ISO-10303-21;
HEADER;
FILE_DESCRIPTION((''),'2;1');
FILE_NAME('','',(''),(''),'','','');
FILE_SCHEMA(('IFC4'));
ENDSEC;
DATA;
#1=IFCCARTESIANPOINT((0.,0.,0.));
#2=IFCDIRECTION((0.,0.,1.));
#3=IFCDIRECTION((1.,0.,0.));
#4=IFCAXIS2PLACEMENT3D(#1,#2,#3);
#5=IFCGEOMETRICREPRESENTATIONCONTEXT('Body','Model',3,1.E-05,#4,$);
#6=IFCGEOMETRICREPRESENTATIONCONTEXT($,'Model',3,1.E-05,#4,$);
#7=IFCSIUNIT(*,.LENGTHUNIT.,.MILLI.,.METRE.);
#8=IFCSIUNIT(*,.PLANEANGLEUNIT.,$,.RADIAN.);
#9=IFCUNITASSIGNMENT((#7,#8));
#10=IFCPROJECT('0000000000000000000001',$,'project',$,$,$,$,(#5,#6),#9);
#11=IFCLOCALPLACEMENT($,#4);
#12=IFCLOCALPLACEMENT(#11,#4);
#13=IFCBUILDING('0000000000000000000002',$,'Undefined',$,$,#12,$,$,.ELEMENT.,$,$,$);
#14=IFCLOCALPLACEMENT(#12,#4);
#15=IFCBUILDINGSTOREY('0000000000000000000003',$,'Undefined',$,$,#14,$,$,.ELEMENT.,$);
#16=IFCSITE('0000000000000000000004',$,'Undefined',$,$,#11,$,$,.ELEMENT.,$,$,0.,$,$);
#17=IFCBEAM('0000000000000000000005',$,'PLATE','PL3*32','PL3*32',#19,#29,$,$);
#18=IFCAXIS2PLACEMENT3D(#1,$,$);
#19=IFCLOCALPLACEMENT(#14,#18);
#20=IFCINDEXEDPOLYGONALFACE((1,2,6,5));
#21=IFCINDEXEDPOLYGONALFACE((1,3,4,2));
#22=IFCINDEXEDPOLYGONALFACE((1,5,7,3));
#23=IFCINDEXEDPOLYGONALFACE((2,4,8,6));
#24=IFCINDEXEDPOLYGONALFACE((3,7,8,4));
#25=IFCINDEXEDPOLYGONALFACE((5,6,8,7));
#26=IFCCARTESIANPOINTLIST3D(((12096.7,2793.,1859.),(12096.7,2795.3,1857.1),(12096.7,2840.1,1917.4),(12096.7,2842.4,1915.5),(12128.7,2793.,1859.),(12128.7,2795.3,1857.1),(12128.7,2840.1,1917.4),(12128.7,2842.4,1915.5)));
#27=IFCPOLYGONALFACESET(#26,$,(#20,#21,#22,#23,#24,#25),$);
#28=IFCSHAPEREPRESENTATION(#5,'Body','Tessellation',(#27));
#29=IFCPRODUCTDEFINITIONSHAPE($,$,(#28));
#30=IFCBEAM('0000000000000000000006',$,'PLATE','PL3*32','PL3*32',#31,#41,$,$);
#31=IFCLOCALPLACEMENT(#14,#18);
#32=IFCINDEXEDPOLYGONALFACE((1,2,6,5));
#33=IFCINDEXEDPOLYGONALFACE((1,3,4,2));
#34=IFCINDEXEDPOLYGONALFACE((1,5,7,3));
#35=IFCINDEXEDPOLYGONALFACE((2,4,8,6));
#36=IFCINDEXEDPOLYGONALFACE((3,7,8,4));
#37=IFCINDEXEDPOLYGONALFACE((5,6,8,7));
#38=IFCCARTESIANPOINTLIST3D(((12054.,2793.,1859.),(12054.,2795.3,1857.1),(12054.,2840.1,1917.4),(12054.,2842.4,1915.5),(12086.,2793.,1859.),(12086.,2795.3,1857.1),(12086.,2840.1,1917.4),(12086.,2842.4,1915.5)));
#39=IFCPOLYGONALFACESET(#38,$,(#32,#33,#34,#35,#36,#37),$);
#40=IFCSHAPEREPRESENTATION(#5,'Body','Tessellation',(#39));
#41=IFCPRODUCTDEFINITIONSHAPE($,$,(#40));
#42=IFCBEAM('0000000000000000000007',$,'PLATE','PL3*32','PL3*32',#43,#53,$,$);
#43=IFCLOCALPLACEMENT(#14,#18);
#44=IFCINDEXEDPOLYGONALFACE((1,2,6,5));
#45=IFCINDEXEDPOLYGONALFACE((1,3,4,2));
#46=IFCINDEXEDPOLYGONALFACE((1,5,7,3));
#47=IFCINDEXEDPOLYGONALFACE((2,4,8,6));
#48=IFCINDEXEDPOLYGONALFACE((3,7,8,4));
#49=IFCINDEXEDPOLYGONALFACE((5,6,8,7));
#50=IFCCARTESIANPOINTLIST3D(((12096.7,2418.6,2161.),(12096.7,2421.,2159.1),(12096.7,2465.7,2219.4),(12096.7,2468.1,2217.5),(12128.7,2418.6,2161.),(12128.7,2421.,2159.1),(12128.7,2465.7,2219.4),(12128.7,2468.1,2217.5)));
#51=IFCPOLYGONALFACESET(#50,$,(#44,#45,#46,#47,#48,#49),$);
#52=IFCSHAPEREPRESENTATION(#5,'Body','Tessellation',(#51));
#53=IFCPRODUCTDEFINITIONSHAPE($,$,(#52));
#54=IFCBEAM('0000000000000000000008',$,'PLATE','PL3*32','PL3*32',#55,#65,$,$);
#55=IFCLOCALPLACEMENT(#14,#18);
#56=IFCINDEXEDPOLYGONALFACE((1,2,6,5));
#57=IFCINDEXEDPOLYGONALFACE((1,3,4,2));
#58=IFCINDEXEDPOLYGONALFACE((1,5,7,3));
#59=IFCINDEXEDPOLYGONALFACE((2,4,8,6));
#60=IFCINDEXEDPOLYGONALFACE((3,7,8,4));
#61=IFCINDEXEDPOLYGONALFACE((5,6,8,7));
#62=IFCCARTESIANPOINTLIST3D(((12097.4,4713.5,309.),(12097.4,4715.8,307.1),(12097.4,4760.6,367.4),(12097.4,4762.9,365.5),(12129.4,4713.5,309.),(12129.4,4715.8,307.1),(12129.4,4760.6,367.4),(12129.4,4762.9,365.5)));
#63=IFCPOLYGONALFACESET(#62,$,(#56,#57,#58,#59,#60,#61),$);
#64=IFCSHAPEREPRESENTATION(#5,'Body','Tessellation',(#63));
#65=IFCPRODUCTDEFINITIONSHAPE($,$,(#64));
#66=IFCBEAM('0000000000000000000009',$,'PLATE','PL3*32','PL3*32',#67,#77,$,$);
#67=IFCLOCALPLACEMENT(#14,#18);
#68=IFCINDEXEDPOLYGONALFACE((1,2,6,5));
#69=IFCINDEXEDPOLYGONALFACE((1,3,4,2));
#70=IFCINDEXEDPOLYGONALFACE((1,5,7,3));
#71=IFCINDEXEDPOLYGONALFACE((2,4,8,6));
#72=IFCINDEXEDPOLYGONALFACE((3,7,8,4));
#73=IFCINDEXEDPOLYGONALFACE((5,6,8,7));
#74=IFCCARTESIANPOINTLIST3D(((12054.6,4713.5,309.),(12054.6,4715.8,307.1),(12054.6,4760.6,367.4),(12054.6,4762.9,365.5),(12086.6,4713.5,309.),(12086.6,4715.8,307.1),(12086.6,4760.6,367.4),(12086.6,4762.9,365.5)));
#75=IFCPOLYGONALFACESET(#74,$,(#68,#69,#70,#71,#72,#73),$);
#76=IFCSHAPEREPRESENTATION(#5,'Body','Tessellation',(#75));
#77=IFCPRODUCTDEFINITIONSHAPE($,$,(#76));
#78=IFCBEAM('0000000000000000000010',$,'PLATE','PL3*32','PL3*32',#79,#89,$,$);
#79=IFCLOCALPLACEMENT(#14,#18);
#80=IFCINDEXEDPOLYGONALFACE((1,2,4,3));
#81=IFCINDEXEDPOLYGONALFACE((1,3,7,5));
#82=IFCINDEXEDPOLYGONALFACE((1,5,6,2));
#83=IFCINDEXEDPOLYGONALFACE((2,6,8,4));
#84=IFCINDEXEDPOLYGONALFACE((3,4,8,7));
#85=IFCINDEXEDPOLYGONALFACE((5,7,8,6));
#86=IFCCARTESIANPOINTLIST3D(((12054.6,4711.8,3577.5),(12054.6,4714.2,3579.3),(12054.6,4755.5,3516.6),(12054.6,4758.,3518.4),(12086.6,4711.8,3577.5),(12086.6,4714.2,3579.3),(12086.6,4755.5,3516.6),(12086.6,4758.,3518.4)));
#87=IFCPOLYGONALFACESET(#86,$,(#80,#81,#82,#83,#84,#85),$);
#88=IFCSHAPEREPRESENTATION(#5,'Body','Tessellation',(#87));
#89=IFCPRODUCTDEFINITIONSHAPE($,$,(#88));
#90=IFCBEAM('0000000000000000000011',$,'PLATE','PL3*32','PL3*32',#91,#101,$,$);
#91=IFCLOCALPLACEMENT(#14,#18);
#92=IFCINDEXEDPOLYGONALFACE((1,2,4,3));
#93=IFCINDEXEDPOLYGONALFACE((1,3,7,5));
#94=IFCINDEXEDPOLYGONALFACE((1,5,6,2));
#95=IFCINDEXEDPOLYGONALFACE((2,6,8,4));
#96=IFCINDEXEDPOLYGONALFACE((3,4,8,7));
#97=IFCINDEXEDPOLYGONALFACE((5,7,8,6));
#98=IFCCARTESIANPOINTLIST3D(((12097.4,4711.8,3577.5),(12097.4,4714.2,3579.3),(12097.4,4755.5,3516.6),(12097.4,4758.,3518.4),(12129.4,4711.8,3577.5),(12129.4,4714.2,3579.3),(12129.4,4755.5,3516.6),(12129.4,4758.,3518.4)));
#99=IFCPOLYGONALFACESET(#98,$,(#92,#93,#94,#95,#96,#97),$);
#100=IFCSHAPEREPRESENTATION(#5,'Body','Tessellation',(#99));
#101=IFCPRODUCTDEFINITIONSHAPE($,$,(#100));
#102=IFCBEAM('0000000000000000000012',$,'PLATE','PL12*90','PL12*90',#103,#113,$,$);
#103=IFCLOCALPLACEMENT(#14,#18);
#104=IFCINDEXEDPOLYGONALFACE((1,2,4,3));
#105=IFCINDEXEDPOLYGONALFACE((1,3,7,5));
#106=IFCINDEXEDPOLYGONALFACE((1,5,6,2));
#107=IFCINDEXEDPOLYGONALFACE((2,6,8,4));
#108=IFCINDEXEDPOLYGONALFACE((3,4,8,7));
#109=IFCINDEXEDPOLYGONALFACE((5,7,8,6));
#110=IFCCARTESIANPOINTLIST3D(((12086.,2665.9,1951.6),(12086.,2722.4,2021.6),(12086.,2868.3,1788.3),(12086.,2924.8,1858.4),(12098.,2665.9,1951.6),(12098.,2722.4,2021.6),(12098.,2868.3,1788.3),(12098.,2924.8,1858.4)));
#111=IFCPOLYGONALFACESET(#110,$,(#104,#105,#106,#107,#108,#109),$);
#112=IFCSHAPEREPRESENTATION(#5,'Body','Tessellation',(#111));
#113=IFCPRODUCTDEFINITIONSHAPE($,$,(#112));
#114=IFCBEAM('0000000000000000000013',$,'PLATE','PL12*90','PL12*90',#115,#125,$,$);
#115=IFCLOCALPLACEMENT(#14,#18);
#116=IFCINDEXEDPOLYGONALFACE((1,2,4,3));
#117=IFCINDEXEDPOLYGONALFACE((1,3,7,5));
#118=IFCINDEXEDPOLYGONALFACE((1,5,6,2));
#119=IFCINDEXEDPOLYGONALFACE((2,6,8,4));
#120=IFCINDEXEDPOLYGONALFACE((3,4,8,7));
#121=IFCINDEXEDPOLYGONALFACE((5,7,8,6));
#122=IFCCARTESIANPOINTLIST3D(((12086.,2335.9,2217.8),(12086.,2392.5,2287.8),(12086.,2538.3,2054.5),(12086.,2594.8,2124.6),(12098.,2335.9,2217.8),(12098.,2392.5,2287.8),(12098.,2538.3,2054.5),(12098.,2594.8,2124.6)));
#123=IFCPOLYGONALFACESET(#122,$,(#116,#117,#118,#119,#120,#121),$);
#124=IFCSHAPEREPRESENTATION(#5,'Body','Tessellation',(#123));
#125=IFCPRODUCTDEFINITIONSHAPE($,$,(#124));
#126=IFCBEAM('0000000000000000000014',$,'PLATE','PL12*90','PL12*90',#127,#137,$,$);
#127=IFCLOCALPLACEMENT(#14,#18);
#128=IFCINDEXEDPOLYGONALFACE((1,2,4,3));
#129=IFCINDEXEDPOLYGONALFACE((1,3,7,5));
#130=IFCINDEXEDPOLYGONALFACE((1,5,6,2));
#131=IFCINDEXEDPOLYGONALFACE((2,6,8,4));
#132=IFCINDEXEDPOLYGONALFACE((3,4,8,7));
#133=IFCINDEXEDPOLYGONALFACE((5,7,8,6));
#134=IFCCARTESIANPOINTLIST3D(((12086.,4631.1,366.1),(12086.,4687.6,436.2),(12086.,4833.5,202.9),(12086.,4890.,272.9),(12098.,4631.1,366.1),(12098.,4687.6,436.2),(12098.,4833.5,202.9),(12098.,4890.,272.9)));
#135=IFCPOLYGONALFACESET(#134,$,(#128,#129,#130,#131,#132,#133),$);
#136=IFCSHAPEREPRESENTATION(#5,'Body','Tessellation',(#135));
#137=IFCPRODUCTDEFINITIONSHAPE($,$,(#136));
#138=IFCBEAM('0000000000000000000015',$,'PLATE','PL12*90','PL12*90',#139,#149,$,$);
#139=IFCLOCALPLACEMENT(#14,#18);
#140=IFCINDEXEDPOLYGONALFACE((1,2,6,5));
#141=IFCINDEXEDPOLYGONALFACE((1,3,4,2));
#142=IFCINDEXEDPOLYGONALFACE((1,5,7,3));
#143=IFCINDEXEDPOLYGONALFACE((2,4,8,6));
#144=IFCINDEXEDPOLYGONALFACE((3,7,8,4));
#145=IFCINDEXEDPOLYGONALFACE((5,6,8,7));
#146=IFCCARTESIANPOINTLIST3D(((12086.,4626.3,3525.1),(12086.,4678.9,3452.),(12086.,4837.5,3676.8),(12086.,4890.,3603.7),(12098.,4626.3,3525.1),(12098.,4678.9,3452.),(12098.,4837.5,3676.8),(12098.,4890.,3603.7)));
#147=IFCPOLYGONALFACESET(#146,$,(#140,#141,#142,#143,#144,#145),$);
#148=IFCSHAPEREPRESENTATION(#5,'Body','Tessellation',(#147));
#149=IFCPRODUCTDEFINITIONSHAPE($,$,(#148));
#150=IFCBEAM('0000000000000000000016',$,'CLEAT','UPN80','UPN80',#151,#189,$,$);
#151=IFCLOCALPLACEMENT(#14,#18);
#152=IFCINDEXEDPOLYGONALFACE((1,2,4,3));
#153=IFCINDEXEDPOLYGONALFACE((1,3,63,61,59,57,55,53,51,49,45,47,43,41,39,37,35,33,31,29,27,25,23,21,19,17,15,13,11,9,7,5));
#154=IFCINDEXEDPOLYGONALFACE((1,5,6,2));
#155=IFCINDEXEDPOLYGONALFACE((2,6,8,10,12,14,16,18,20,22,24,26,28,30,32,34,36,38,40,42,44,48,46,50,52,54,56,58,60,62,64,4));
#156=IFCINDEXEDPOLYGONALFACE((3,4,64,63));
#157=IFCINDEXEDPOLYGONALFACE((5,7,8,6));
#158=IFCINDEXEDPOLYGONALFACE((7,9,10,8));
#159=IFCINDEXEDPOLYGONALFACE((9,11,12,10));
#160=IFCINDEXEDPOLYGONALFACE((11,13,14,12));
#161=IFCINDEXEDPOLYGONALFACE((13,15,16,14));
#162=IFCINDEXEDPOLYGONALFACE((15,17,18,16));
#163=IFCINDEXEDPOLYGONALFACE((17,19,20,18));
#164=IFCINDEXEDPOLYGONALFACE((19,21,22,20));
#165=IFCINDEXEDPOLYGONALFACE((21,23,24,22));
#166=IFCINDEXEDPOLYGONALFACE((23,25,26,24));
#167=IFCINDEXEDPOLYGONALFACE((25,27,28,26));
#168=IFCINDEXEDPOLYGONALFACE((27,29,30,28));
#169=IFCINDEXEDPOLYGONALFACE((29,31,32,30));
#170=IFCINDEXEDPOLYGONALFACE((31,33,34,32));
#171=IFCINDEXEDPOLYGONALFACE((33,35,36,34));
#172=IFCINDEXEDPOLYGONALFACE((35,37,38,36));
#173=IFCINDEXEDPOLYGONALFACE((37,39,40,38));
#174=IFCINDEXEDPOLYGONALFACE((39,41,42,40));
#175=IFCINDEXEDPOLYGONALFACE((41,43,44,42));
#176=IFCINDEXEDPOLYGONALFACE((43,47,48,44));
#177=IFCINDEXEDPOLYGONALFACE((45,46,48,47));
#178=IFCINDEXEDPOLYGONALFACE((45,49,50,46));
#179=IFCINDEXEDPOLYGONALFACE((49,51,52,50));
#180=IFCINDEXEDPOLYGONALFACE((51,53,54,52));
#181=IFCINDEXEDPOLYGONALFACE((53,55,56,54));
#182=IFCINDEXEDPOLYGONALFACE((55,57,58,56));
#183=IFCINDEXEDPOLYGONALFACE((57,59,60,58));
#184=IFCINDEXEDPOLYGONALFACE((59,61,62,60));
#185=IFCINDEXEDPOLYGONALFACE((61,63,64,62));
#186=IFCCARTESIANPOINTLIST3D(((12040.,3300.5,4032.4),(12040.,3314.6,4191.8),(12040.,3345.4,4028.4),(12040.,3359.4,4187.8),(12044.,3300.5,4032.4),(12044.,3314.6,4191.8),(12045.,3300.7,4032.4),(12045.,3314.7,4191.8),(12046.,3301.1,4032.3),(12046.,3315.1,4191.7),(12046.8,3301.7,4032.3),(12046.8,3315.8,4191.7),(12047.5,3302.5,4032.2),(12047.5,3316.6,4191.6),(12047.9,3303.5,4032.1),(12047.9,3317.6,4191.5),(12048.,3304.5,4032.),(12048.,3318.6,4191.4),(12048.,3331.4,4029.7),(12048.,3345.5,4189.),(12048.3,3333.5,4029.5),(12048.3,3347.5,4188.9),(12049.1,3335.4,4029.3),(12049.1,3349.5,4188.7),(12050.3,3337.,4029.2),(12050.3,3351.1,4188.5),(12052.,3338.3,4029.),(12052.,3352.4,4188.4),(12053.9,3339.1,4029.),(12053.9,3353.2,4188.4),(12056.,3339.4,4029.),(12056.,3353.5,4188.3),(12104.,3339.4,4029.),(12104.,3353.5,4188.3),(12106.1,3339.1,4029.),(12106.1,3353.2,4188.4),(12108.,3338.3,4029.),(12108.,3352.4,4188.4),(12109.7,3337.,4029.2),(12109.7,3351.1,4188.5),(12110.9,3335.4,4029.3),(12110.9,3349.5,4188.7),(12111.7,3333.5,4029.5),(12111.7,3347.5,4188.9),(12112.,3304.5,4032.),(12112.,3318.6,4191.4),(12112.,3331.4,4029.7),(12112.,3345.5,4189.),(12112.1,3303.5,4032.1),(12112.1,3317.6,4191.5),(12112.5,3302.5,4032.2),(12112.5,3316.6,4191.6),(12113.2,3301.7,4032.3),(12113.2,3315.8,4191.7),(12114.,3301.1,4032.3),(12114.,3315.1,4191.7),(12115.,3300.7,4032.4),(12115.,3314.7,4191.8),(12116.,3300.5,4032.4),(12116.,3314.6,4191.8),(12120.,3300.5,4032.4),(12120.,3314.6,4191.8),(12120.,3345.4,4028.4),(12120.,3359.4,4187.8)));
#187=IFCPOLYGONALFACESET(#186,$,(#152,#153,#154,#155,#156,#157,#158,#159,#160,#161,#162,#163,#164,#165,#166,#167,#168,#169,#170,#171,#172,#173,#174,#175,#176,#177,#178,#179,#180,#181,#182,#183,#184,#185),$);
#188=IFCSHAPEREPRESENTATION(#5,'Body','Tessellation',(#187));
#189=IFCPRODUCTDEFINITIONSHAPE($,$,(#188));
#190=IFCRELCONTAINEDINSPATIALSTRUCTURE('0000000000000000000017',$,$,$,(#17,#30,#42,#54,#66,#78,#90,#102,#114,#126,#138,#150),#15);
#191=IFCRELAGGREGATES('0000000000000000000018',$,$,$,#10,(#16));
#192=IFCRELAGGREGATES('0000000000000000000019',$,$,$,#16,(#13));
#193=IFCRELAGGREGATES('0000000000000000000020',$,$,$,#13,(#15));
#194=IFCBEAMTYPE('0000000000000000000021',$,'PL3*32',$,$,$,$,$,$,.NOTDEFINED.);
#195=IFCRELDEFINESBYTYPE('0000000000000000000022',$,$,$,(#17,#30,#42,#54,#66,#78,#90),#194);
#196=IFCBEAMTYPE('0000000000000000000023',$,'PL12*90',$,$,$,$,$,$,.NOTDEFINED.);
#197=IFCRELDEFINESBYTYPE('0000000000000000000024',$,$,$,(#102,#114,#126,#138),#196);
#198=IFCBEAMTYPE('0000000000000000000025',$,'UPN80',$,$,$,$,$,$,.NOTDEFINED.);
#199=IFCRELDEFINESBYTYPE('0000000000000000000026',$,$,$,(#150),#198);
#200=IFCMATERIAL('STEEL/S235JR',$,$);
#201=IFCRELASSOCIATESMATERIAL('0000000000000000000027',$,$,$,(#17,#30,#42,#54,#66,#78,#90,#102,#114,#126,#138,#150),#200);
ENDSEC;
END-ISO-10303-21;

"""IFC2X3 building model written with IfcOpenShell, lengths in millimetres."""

from ifc_helpers import new_model, si_unit, frame, origin_with_axes, origin_2d_with_axis, place, context, project, spatial, rectangle, u_section, extrude, material, type_object, element, save


model = new_model("IFC2X3")

# Units and contexts
model_context_1 = context("Model", 3, precision=1e-05, world=origin_with_axes(), identifier="Body")
model_context_2 = context("Model", 3, precision=1e-05, world=origin_with_axes())
ifc_project = project(units=[si_unit("LENGTHUNIT", "METRE", prefix="MILLI"), si_unit("PLANEANGLEUNIT", "RADIAN")], contexts=[model_context_1, model_context_2])

# Site, building, storey
site_placement = place(None, origin_with_axes())
site = spatial("IfcSite", under=ifc_project, at=site_placement, Name="Undefined", CompositionType="ELEMENT", RefElevation=0.0)
building_placement = place(site_placement, origin_with_axes())
building = spatial("IfcBuilding", under=site, at=building_placement, Name="Undefined", CompositionType="ELEMENT")
storey_placement = place(building_placement, origin_with_axes())
storey = spatial("IfcBuildingStorey", under=building, at=storey_placement, Name="Undefined", CompositionType="ELEMENT")

# Shared definitions
ifc_material = material(Name="STEEL/S235JR")

# Beams
beam_type_1 = type_object("IfcBeamType", Name="PL3*32", PredefinedType="NOTDEFINED")
for number, where, z_axis, x_axis, name in (
    (1, (12112.7, 2794.2, 1858.1), (-1.0, 0.0, 0.0), (0.0, 0.627892, 0.7783), "PLATE"),
    (2, (12070.0, 2794.2, 1858.1), (1.0, 0.0, 0.0), (0.0, 0.627892, 0.7783), "PLATE"),
):
    element("IfcBeam", number, at=place(storey_placement, frame(where, z_axis=z_axis, x_axis=x_axis)), inside=storey, type_object=beam_type_1, material=ifc_material, Name=name, Description="PL3*32", ObjectType="PL3*32", context=model_context_1, shape_type="SweptSolid", body=[
        extrude(rectangle(XDim=3.0, YDim=32.0, at=origin_2d_with_axis()), frame((75.0, 0.0, 0.0), z_axis=(-1.0, 0.0, 0.0), x_axis=(0.0, -1.0, 0.0)), (0.0, 0.0, 1.0), 75.0),
    ])
beam_1_placement = place(storey_placement, frame((12112.7, 2419.8, 2160.1), z_axis=(-1.0, 0.0, 0.0), x_axis=(0.0, 0.627892, 0.7783)))
element("IfcBeam", 3, at=beam_1_placement, inside=storey, type_object=beam_type_1, material=ifc_material, Name="PLATE", Description="PL3*32", ObjectType="PL3*32", context=model_context_1, shape_type="SweptSolid", body=[
    extrude(rectangle(XDim=3.0, YDim=32.0, at=origin_2d_with_axis()), frame((75.0, 0.0, 0.0), z_axis=(-1.0, 0.0, 0.0), x_axis=(0.0, -1.0, 0.0)), (0.0, 0.0, 1.0), 75.0),
])
for number, where, z_axis, x_axis, name in (
    (4, (12113.4, 4761.8, 366.4), (-1.0, 0.0, 0.0), (0.0, -0.627936, -0.778265), "PLATE"),
    (5, (12070.6, 4761.8, 366.4), (1.0, 0.0, 0.0), (0.0, -0.627936, -0.778265), "PLATE"),
):
    element("IfcBeam", number, at=place(storey_placement, frame(where, z_axis=z_axis, x_axis=x_axis)), inside=storey, type_object=beam_type_1, material=ifc_material, Name=name, Description="PL3*32", ObjectType="PL3*32", context=model_context_1, shape_type="SweptSolid", body=[
        extrude(rectangle(XDim=3.0, YDim=32.0, at=origin_2d_with_axis()), frame((75.0, 0.0, 0.0), z_axis=(-1.0, 0.0, 0.0), x_axis=(0.0, -1.0, 0.0)), (0.0, 0.0, 1.0), 75.0),
    ])
for number, where, z_axis, x_axis, name in (
    (6, (12070.6, 4756.8, 3517.5), (1.0, 0.0, 0.0), (0.0, -0.583503, 0.812111), "PLATE"),
    (7, (12113.4, 4756.8, 3517.5), (-1.0, 0.0, 0.0), (0.0, -0.583503, 0.812111), "PLATE"),
):
    element("IfcBeam", number, at=place(storey_placement, frame(where, z_axis=z_axis, x_axis=x_axis)), inside=storey, type_object=beam_type_1, material=ifc_material, Name=name, Description="PL3*32", ObjectType="PL3*32", context=model_context_1, shape_type="SweptSolid", body=[
        extrude(rectangle(XDim=3.0, YDim=32.0, at=origin_2d_with_axis()), frame((75.0, 0.0, 0.0), z_axis=(-1.0, 0.0, 0.0), x_axis=(0.0, -1.0, 0.0)), (0.0, 0.0, 1.0), 75.0),
    ])
beam_type_2 = type_object("IfcBeamType", Name="PL12*90", PredefinedType="NOTDEFINED")
for number, where, z_axis, x_axis, name in (
    (8, (12092.0, 2694.2, 1986.6), (0.0, 0.627892, 0.7783), (0.0, 0.7783, -0.627892), "PLATE"),
    (9, (12092.0, 2566.6, 2089.6), (0.0, 0.627892, 0.7783), (0.0, -0.7783, 0.627892), "PLATE"),
):
    element("IfcBeam", number, at=place(storey_placement, frame(where, z_axis=z_axis, x_axis=x_axis)), inside=storey, type_object=beam_type_2, material=ifc_material, Name=name, Description="PL12*90", ObjectType="PL12*90", context=model_context_1, shape_type="SweptSolid", body=[
        extrude(rectangle(XDim=12.0, YDim=90.0, at=origin_2d_with_axis()), frame((260.0, 0.0, 0.0), z_axis=(-1.0, 0.0, 0.0), x_axis=(0.0, -1.0, 0.0)), (0.0, 0.0, 1.0), 260.0),
    ])
beam_2_placement = place(storey_placement, frame((12092.0, 4861.7, 237.9), z_axis=(0.0, -0.627907, -0.778288), x_axis=(0.0, -0.778288, 0.627907)))
element("IfcBeam", 10, at=beam_2_placement, inside=storey, type_object=beam_type_2, material=ifc_material, Name="PLATE", Description="PL12*90", ObjectType="PL12*90", context=model_context_1, shape_type="SweptSolid", body=[
    extrude(rectangle(XDim=12.0, YDim=90.0, at=origin_2d_with_axis()), frame((260.0, 0.0, 0.0), z_axis=(-1.0, 0.0, 0.0), x_axis=(0.0, -1.0, 0.0)), (0.0, 0.0, 1.0), 260.0),
])
beam_3_placement = place(storey_placement, frame((12092.0, 4863.7, 3640.2), z_axis=(0.0, -0.583503, 0.812111), x_axis=(0.0, -0.812111, -0.583503)))
element("IfcBeam", 11, at=beam_3_placement, inside=storey, type_object=beam_type_2, material=ifc_material, Name="PLATE", Description="PL12*90", ObjectType="PL12*90", context=model_context_1, shape_type="SweptSolid", body=[
    extrude(rectangle(XDim=12.0, YDim=90.0, at=origin_2d_with_axis()), frame((260.0, 0.0, 0.0), z_axis=(-1.0, 0.0, 0.0), x_axis=(0.0, -1.0, 0.0)), (0.0, 0.0, 1.0), 260.0),
])
beam_type_3 = type_object("IfcBeamType", Name="UPN80", PredefinedType="NOTDEFINED")
beam_4_placement = place(storey_placement, frame((12080.0, 3322.9, 4030.4), z_axis=(-1.0, 0.0, 0.0), x_axis=(0.0, 0.08801, 0.99612)))
element("IfcBeam", 12, at=beam_4_placement, inside=storey, type_object=beam_type_3, material=ifc_material, Name="CLEAT", Description="UPN80", ObjectType="UPN80", context=model_context_1, shape_type="SweptSolid", body=[
    extrude(u_section(Depth=80.0, FlangeWidth=45.0, WebThickness=6.0, FlangeThickness=8.0, FilletRadius=8.0, EdgeRadius=4.0, at=origin_2d_with_axis()), frame((160.0, 0.0, 0.0), z_axis=(-1.0, 0.0, 0.0), x_axis=(0.0, -1.0, 0.0)), (0.0, 0.0, 1.0), 160.0),
])

save(model, "model.ifc")
